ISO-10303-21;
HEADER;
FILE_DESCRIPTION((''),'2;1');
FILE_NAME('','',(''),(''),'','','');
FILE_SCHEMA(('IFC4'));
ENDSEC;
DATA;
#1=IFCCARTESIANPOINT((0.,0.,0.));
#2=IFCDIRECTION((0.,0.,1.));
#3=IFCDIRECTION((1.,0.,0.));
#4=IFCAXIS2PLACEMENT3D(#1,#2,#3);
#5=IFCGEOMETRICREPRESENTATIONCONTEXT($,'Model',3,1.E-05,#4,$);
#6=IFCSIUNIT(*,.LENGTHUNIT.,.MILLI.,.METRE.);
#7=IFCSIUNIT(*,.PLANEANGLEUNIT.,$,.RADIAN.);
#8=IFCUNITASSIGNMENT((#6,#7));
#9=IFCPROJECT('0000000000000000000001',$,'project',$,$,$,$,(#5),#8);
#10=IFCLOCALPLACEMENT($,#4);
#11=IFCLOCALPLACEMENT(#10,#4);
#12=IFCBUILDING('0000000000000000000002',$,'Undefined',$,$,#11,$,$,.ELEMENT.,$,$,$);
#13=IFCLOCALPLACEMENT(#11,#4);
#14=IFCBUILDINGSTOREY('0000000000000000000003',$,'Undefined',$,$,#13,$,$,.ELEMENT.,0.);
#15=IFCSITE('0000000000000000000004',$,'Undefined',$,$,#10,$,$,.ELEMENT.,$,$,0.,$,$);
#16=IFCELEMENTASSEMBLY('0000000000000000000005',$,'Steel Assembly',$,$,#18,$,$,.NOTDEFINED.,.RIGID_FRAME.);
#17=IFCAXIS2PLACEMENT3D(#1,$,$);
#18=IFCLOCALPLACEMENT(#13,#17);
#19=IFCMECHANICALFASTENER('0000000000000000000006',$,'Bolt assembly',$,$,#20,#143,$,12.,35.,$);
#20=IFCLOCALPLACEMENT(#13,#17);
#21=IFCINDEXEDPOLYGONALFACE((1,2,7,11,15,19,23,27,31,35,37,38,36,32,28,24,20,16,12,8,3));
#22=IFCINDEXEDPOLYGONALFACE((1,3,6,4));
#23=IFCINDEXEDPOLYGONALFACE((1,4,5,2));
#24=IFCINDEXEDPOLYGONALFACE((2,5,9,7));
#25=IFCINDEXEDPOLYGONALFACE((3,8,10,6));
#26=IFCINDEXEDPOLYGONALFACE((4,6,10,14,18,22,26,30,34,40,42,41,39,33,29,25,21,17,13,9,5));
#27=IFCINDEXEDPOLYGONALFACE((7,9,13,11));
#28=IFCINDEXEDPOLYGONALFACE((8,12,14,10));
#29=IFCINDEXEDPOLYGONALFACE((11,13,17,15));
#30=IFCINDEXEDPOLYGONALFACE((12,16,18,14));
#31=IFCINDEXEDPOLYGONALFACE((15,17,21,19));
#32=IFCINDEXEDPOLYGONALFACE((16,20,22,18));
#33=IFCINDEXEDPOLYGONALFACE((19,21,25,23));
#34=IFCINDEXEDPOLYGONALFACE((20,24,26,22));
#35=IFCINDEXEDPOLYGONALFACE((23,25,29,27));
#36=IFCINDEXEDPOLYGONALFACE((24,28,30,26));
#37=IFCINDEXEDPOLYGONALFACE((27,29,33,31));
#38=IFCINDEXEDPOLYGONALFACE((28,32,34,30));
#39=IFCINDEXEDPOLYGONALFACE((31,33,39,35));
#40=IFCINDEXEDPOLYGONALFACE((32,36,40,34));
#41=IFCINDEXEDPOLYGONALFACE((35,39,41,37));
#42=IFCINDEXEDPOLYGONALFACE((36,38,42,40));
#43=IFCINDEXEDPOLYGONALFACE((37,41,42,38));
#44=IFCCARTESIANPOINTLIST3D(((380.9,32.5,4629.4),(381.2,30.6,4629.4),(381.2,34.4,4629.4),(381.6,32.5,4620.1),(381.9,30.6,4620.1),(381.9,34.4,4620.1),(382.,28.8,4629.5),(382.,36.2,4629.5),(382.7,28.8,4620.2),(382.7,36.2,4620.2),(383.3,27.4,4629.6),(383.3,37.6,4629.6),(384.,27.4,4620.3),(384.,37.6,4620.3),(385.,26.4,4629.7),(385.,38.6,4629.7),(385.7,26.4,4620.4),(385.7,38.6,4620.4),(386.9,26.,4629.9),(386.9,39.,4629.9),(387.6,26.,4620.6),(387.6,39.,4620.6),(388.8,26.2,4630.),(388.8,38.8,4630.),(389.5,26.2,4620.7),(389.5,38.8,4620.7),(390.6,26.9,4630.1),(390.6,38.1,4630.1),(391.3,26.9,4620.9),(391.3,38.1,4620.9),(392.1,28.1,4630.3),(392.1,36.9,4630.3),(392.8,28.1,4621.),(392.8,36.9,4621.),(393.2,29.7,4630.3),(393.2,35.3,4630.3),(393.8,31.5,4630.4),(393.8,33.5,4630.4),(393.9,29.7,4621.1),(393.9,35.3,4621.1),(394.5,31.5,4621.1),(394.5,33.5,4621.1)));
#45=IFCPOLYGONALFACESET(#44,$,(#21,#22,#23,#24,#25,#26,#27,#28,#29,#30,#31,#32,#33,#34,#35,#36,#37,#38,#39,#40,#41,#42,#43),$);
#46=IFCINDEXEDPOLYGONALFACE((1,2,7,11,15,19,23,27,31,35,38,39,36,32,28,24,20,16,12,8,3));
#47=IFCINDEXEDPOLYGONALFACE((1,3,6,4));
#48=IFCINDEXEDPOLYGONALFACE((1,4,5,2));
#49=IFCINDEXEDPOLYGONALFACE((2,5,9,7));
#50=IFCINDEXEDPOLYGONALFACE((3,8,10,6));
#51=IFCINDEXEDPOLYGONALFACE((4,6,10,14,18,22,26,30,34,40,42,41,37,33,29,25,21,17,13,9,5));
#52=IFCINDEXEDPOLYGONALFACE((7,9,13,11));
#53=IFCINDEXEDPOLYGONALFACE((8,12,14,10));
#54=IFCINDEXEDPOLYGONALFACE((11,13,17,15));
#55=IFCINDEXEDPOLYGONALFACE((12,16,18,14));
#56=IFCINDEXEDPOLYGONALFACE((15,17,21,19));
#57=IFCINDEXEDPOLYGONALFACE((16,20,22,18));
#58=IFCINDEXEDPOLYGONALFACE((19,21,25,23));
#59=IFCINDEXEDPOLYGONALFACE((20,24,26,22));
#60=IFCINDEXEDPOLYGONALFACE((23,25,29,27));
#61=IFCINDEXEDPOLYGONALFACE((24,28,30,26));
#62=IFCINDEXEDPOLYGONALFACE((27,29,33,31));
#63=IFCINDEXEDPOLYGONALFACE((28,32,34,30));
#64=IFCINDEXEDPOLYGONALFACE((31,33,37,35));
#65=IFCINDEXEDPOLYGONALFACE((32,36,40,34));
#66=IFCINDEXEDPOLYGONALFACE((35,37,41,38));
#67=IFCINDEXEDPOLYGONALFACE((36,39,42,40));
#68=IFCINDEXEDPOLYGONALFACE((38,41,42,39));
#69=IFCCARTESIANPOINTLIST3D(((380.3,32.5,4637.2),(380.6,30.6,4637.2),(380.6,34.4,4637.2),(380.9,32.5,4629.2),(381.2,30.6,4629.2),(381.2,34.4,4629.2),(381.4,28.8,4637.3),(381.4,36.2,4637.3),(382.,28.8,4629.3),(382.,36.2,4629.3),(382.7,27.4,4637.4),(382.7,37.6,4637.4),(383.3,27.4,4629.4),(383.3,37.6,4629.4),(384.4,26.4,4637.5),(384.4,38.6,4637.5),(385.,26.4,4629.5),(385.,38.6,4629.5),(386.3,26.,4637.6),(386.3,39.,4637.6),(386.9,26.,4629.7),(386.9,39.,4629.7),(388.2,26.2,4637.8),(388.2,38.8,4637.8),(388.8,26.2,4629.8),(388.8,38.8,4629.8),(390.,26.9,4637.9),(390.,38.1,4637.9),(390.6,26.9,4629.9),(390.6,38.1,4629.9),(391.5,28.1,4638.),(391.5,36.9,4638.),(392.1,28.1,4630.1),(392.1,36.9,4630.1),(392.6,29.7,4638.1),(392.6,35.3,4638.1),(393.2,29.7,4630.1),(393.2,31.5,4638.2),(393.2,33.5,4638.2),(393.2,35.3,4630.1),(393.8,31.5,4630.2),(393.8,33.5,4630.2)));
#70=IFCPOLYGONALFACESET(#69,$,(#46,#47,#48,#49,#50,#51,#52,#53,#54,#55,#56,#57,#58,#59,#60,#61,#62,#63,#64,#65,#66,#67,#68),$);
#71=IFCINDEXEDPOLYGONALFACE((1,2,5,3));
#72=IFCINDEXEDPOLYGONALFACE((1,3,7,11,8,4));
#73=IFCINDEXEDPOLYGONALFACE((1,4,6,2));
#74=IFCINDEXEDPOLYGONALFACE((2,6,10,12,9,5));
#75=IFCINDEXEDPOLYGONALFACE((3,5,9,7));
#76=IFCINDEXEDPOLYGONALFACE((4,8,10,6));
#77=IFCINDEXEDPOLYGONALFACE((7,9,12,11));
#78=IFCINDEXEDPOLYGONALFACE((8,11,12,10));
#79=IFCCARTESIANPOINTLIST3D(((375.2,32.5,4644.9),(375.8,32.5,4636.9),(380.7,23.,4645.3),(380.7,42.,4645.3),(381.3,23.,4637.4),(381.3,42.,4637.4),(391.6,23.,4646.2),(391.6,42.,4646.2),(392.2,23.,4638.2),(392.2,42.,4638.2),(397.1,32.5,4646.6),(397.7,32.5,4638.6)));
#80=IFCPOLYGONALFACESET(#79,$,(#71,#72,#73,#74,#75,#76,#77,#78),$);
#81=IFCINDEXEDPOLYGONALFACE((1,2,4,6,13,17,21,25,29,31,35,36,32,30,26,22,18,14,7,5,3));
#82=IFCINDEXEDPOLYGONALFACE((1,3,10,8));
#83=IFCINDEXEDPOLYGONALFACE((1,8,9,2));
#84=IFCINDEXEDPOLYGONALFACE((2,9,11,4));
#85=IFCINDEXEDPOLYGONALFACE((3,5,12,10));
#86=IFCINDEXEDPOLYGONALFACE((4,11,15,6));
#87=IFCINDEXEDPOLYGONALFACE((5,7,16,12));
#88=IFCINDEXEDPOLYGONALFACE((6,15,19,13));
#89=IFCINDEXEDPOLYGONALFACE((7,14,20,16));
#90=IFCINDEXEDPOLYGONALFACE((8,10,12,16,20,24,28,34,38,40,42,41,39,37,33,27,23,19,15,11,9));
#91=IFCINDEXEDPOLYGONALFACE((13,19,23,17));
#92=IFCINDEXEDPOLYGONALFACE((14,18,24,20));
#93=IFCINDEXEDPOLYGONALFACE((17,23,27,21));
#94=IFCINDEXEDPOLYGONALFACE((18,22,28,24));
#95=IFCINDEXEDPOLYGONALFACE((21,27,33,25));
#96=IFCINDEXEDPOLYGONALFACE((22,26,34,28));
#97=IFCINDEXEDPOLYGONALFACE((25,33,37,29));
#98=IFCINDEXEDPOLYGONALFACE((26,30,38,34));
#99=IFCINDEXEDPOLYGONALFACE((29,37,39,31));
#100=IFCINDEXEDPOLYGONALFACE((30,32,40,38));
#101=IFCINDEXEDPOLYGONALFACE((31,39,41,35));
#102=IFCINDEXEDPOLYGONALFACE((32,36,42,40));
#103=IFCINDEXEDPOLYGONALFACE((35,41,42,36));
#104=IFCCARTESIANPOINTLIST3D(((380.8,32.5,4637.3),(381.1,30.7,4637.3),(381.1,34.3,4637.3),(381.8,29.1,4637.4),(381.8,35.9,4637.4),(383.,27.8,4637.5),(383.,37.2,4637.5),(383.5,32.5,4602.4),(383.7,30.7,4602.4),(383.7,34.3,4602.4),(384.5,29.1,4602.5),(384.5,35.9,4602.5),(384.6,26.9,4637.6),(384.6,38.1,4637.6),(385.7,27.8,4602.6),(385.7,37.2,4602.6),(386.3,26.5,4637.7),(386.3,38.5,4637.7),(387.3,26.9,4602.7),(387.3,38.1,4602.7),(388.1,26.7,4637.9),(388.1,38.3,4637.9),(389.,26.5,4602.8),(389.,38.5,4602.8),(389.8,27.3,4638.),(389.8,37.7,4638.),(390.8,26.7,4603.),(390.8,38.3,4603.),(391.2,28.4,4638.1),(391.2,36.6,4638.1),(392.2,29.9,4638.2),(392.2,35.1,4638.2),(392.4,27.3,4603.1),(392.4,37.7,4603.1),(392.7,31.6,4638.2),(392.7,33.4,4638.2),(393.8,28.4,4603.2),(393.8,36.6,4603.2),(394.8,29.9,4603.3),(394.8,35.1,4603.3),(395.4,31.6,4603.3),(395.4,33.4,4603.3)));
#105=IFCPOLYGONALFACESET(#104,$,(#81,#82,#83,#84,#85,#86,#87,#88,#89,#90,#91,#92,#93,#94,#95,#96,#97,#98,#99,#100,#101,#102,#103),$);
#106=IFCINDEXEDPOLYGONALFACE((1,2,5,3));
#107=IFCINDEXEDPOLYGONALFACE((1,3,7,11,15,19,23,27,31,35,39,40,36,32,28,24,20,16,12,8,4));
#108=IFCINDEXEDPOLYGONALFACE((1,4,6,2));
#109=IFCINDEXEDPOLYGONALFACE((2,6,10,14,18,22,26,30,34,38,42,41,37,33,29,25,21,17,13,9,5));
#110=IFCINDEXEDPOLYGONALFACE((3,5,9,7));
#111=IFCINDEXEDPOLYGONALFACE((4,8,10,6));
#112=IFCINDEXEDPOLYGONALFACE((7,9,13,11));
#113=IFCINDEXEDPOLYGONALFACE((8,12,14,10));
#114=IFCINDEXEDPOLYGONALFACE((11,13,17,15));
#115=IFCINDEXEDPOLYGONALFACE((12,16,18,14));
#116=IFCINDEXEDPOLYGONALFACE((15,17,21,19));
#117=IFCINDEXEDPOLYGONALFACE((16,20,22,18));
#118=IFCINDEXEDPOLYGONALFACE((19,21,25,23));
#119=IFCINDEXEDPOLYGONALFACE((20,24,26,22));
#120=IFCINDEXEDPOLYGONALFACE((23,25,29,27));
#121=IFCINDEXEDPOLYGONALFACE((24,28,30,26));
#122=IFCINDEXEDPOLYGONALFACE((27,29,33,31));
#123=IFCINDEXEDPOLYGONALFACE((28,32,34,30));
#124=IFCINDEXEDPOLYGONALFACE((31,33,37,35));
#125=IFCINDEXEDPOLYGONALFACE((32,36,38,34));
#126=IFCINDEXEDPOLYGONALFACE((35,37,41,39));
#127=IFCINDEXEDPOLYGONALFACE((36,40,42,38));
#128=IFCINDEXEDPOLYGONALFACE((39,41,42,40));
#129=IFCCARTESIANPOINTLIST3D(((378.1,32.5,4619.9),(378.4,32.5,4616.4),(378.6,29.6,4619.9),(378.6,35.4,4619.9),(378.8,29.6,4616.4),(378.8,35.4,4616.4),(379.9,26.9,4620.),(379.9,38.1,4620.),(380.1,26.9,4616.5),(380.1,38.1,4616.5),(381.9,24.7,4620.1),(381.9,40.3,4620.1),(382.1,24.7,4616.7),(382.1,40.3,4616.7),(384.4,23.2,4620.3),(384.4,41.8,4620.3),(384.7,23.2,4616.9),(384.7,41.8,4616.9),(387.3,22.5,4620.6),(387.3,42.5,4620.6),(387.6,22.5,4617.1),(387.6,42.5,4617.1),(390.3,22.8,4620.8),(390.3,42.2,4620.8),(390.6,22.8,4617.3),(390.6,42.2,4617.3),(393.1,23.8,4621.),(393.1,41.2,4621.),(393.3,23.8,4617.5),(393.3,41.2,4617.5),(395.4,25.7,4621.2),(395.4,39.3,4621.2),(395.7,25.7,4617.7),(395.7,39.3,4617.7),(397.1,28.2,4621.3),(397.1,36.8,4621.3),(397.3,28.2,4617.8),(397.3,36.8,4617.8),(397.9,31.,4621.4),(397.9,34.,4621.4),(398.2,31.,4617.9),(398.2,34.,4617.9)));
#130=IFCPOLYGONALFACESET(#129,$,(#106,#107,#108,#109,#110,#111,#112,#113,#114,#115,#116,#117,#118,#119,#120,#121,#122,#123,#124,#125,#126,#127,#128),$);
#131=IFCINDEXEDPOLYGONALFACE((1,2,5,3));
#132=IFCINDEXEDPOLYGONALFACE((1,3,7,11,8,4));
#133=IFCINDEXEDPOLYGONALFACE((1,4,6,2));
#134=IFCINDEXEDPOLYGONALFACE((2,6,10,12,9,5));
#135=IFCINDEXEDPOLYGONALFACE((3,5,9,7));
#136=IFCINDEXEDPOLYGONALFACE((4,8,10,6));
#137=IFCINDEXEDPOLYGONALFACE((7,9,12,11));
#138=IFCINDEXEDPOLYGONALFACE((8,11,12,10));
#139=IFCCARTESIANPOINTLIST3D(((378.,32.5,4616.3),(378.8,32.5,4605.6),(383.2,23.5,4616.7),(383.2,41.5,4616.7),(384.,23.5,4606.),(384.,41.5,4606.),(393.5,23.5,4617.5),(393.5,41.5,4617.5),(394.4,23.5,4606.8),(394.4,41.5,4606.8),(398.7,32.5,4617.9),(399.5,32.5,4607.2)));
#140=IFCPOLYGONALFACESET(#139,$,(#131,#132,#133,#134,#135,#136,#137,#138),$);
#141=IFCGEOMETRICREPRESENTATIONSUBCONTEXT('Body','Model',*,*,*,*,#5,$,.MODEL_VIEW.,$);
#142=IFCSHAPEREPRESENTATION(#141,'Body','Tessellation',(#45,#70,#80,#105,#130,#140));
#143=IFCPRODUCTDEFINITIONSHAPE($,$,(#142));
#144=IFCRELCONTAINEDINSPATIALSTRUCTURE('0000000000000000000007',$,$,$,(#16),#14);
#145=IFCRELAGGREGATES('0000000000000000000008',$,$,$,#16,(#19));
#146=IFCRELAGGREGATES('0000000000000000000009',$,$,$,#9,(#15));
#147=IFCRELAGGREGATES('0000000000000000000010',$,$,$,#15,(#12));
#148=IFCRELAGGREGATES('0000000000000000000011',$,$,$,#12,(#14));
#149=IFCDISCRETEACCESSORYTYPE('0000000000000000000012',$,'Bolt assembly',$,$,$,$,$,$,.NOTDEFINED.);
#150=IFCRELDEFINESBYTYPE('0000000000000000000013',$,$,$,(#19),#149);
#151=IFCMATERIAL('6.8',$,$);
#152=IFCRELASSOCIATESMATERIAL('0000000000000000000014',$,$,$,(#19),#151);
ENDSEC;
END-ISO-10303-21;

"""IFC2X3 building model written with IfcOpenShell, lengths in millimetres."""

from ifc_helpers import new_model, si_unit, frame, origin_with_axes, origin_2d_with_axis, place, context, subcontext, project, spatial, polyline, circle, outline, extrude, source, transform, mapped, material, type_object, element, aggregate, save


model = new_model("IFC2X3")

# Units and contexts
model_context = context("Model", 3, precision=1e-05, world=origin_with_axes())
body_context = subcontext(model_context, "Body", "Model", "MODEL_VIEW")
ifc_project = project(units=[si_unit("LENGTHUNIT", "METRE", prefix="MILLI"), si_unit("PLANEANGLEUNIT", "RADIAN")], contexts=[model_context])

# Site, building, storey
site_placement = place(None, origin_with_axes())
site = spatial("IfcSite", under=ifc_project, at=site_placement, Name="Undefined", CompositionType="ELEMENT", RefElevation=0.0)
building_placement = place(site_placement, origin_with_axes())
building = spatial("IfcBuilding", under=site, at=building_placement, Name="Undefined", CompositionType="ELEMENT")
storey_placement = place(building_placement, origin_with_axes())
storey = spatial("IfcBuildingStorey", under=building, at=storey_placement, Name="Undefined", CompositionType="ELEMENT", Elevation=0.0)

# Element assembly, mechanical fastener
assembly_1_placement = place(storey_placement, origin_with_axes())
assembly_1 = element("IfcElementAssembly", 1, at=assembly_1_placement, inside=storey, Name="Steel Assembly", AssemblyPlace="NOTDEFINED", PredefinedType="RIGID_FRAME")
ifc_material_1 = material(Name="6.8")
discrete_accessory_type_1 = type_object("IfcDiscreteAccessoryType", Name="Bolt assembly")
shared_shape_1 = source(origin_with_axes(), body_context, "Body", "SweptSolid", [
    extrude(circle(Radius=6.5, at=origin_2d_with_axis()), frame((0.0, -0.1, 0.0), z_axis=(0.0, 1.0, 0.0), x_axis=(1.0, 0.0, 0.0)), (0.0, 0.0, 1.0), 9.3),
    extrude(circle(Radius=6.5, at=origin_2d_with_axis()), frame((0.0, -7.9, 0.0), z_axis=(0.0, 1.0, 0.0), x_axis=(1.0, 0.0, 0.0)), (0.0, 0.0, 1.0), 8.0),
    extrude(outline(polyline([(11.0, 0.0), (5.5, 9.5), (-5.5, 9.5), (-11.0, 0.0), (-5.5, -9.5), (5.5, -9.5), (11.0, 0.0)])), frame((0.0, -16.0, 0.0), z_axis=(0.0, 1.0, 0.0), x_axis=(1.0, 0.0, 0.0)), (0.0, 0.0, 1.0), 8.0),
    extrude(circle(Radius=6.0, at=origin_2d_with_axis()), frame((0.0, -8.0, 0.0), z_axis=(0.0, 1.0, 0.0), x_axis=(1.0, 0.0, 0.0)), (0.0, 0.0, 1.0), 35.0),
    extrude(circle(Radius=10.0, at=origin_2d_with_axis()), frame((0.0, 9.2, 0.0), z_axis=(0.0, 1.0, 0.0), x_axis=(1.0, 0.0, 0.0)), (0.0, 0.0, 1.0), 3.5),
    extrude(outline(polyline([(10.4, 0.0), (5.2, 9.0), (-5.2, 9.0), (-10.4, 0.0), (-5.2, -9.0), (5.2, -9.0), (10.4, 0.0)])), frame((0.0, 12.7, 0.0), z_axis=(0.0, 1.0, 0.0), x_axis=(1.0, 0.0, 0.0)), (0.0, 0.0, 1.0), 10.8),
])
mechanical_fastener_1_placement = place(assembly_1_placement, frame((387.4, 32.5, 4629.8), z_axis=(0.0, -1.0, 0.0), x_axis=(-0.997054, 0.0, -0.076696)))
mechanical_fastener_1 = element("IfcMechanicalFastener", 2, at=mechanical_fastener_1_placement, type_object=discrete_accessory_type_1, material=ifc_material_1, Name="Bolt assembly", NominalDiameter=12.0, NominalLength=35.0, context=body_context, shape_type="MappedRepresentation", body=[
    mapped(shared_shape_1, transform((0.0, 0.0, 0.0))),
])
aggregate(assembly_1, [mechanical_fastener_1])

save(model, "model.ifc")
